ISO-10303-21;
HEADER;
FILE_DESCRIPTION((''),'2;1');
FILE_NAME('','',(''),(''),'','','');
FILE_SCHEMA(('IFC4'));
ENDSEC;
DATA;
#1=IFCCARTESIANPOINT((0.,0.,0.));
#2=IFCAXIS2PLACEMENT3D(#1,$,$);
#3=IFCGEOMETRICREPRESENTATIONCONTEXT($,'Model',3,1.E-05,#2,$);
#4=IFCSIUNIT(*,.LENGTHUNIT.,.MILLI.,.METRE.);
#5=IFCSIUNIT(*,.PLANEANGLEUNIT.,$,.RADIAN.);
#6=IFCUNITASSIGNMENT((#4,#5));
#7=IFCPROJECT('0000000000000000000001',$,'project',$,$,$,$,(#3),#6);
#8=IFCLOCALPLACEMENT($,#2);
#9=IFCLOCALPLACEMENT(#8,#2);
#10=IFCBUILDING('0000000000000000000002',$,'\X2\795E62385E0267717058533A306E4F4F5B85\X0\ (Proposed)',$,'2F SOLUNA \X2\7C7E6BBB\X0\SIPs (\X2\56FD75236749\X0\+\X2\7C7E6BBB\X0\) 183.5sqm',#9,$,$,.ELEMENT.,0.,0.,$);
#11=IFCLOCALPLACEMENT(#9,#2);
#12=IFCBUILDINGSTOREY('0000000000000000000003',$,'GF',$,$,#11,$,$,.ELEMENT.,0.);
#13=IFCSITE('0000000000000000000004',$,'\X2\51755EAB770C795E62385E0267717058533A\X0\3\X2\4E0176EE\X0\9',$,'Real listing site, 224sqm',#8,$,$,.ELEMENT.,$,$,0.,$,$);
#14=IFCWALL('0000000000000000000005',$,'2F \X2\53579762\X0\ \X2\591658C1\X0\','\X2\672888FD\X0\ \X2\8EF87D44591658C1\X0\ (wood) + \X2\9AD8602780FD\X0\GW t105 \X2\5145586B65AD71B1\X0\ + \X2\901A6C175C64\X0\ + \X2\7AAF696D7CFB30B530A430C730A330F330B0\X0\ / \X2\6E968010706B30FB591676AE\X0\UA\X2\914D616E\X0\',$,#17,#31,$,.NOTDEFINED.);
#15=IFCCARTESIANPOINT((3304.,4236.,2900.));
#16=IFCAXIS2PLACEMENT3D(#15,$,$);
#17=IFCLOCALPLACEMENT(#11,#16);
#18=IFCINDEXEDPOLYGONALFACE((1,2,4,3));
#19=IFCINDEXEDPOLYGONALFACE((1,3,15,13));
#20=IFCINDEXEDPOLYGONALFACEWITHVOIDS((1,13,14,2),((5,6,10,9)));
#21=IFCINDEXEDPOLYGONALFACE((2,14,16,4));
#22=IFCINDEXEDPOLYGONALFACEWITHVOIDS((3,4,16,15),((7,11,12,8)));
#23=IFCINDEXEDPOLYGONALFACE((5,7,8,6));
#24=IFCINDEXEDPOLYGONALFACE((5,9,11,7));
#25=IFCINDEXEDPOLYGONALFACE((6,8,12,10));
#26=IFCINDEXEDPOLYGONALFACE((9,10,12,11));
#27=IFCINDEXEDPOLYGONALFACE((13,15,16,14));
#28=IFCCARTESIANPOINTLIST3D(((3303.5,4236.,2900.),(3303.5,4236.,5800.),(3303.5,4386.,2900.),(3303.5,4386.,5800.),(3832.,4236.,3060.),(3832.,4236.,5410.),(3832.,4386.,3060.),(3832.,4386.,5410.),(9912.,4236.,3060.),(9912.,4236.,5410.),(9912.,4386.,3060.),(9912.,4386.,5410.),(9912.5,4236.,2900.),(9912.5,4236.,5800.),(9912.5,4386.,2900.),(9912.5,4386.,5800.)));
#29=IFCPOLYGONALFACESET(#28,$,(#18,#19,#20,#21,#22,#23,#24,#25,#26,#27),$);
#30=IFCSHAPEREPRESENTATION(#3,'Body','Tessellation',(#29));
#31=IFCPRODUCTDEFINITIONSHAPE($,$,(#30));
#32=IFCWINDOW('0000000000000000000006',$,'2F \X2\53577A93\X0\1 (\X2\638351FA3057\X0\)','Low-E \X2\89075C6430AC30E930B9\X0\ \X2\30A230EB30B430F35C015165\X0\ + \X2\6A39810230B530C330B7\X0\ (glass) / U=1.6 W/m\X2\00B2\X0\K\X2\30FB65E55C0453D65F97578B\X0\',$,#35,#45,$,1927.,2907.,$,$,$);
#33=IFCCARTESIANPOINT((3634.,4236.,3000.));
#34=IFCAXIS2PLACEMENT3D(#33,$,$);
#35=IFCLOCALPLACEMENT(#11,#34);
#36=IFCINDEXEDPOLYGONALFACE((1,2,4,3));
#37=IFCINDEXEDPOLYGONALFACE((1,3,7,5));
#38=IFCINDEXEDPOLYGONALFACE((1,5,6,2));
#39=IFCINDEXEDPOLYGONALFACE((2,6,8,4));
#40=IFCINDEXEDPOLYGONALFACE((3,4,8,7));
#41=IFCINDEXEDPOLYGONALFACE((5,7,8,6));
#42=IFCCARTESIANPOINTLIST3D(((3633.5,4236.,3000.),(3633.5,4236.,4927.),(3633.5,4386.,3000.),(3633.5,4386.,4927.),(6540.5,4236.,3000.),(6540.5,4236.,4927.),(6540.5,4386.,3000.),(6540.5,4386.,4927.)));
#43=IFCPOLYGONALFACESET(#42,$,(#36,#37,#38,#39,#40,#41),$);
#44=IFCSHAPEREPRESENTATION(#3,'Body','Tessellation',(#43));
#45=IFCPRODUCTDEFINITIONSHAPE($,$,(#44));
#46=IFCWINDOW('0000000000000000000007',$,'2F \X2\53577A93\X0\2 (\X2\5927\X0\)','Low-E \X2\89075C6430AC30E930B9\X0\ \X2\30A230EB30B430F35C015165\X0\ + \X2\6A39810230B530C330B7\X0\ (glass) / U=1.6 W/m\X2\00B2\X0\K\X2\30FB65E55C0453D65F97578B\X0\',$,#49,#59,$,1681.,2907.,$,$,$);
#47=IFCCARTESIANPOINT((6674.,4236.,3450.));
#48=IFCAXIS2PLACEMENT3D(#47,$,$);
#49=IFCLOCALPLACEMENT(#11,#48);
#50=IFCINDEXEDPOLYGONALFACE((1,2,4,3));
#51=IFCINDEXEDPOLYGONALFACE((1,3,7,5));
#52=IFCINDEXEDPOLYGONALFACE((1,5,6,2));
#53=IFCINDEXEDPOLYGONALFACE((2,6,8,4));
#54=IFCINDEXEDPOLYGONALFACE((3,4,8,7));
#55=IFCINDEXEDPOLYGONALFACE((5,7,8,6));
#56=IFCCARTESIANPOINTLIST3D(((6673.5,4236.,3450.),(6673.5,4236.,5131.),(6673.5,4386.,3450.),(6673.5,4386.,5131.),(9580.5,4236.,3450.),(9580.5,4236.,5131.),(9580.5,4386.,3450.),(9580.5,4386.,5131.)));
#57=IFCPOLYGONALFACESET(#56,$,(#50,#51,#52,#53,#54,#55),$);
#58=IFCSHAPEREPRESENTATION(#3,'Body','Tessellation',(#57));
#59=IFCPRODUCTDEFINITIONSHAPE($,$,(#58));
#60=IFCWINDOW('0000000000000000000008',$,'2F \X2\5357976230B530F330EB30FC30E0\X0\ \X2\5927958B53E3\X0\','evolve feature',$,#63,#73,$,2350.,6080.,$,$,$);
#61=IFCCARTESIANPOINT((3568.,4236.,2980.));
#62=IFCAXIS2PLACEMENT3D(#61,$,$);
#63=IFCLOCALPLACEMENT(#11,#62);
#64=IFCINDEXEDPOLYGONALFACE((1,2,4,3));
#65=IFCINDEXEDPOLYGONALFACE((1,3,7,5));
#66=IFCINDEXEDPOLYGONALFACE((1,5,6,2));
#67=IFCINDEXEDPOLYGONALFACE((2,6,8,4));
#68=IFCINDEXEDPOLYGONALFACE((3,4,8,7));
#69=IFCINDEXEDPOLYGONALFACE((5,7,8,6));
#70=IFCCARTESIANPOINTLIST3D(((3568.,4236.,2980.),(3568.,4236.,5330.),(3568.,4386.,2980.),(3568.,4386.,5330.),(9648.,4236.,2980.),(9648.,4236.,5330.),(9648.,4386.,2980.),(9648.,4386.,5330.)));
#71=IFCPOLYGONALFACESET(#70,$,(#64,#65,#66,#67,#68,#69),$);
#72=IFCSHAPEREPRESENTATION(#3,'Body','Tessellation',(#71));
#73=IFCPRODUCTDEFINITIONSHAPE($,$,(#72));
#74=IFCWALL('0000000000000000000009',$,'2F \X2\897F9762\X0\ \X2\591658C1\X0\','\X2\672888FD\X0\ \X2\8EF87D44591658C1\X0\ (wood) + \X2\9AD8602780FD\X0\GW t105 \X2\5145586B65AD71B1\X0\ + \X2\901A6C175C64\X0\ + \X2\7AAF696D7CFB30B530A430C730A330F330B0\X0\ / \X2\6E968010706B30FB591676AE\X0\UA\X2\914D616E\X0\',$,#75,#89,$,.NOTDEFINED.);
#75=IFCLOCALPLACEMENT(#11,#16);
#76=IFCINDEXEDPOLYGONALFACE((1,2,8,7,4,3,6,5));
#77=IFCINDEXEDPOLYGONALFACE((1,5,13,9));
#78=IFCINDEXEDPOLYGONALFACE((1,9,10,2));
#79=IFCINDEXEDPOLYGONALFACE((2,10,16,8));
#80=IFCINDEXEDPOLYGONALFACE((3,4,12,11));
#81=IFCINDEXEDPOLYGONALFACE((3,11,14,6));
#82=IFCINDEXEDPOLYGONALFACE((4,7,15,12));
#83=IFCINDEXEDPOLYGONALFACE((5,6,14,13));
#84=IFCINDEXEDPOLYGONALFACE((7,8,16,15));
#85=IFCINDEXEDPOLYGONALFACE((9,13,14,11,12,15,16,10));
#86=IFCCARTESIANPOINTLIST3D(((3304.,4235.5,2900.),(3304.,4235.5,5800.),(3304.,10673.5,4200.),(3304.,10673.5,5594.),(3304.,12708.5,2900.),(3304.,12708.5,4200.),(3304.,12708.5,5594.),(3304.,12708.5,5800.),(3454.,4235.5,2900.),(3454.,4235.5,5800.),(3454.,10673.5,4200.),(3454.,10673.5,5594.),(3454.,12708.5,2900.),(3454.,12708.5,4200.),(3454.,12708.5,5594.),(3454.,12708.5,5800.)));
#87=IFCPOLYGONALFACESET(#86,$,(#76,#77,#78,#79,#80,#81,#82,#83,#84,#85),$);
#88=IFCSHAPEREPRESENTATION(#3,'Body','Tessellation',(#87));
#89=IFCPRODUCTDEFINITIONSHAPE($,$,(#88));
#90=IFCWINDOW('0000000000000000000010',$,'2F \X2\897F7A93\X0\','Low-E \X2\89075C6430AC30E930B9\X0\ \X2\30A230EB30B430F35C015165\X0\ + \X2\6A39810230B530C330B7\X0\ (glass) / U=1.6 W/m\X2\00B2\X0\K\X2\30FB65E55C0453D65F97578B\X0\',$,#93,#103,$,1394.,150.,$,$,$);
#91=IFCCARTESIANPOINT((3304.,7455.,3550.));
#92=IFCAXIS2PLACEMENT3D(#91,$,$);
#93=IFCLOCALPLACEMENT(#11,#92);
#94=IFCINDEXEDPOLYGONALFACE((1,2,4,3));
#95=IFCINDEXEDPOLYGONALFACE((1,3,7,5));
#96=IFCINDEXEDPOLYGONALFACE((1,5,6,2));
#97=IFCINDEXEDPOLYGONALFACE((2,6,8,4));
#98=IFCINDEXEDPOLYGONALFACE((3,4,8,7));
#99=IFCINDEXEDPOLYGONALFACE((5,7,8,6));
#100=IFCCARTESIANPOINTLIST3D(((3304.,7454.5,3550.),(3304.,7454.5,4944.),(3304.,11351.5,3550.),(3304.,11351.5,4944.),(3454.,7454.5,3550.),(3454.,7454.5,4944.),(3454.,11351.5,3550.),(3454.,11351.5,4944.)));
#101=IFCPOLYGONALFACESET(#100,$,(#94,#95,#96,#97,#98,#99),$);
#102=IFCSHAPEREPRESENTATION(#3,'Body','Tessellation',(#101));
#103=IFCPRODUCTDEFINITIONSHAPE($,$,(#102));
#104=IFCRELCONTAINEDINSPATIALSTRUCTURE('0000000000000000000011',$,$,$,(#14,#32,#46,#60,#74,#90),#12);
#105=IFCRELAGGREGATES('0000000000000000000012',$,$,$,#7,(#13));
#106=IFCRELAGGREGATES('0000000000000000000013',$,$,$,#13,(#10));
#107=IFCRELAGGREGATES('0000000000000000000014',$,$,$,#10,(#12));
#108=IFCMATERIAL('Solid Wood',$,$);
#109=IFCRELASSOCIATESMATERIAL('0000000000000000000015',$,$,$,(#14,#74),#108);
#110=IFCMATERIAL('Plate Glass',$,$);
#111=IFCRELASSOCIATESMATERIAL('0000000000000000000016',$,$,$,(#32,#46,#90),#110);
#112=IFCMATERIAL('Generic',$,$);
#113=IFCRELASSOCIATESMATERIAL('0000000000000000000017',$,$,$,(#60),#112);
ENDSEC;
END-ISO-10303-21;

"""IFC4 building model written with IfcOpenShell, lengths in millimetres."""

from ifc_helpers import new_model, si_unit, frame, frame_2d, origin, place, context, project, spatial, rectangle, extrude, material, element, fill, save


model = new_model("IFC4")

# Units and contexts
model_context = context("Model", 3, precision=1e-05, world=origin())
ifc_project = project(units=[si_unit("LENGTHUNIT", "METRE", prefix="MILLI"), si_unit("PLANEANGLEUNIT", "RADIAN")], contexts=[model_context])

# Site, building, storey
site_placement = place(None, origin())
site = spatial("IfcSite", under=ifc_project, at=site_placement, Name="兵庫県神戸市東灘区3丁目9", ObjectType="Real listing site, 224sqm", CompositionType="ELEMENT", RefElevation=0.0)
building_placement = place(site_placement, origin())
building = spatial("IfcBuilding", under=site, at=building_placement, Name="神戸市東灘区の住宅 (Proposed)", ObjectType="2F SOLUNA 籾殻SIPs (国産杉+籾殻) 183.5sqm", CompositionType="ELEMENT", ElevationOfRefHeight=0.0, ElevationOfTerrain=0.0)
storey_placement = place(building_placement, origin())
storey = spatial("IfcBuildingStorey", under=building, at=storey_placement, Name="GF", CompositionType="ELEMENT", Elevation=0.0)

# Shared definitions
ifc_material_1 = material(Name="Solid Wood")
ifc_material_2 = material(Name="Generic")

# Shared definitions
ifc_material_3 = material(Name="Plate Glass")

# Wall, openings, windows
wall_1_placement = place(storey_placement, frame((3304.0, 4236.0, 2900.0)))
wall_1 = element("IfcWall", 1, at=wall_1_placement, inside=storey, material=ifc_material_1, Name="2F 南面 外壁", Description="木製 軸組外壁 (wood) + 高性能GW t105 充填断熱 + 通気層 + 窯業系サイディング / 準耐火・外皮UA配慮", PredefinedType="NOTDEFINED", context=model_context, shape_type="SweptSolid", body=[
    extrude(rectangle(XDim=6609.0, YDim=150.0, at=frame_2d((3304.0, 75.0))), frame((3304.0, 4236.0, 2900.0)), (0.0, 0.0, 1.0), 2900.0),
])
opening_1_placement = place(storey_placement, frame((3634.0, 4236.0, 3000.0)))
opening_1 = element("IfcOpeningElement", 2, at=opening_1_placement, cuts=wall_1, PredefinedType="NOTDEFINED", context=model_context, shape_type="SweptSolid", body=[
    extrude(rectangle(XDim=2907.0, YDim=150.0, at=frame_2d((1453.0, 75.0))), frame((3634.0, 4236.0, 3000.0)), (0.0, 0.0, 1.0), 1927.0),
])
opening_2_placement = place(storey_placement, frame((6674.0, 4236.0, 3450.0)))
opening_2 = element("IfcOpeningElement", 3, at=opening_2_placement, cuts=wall_1, PredefinedType="NOTDEFINED", context=model_context, shape_type="SweptSolid", body=[
    extrude(rectangle(XDim=2907.0, YDim=150.0, at=frame_2d((1453.0, 75.0))), frame((6674.0, 4236.0, 3450.0)), (0.0, 0.0, 1.0), 1681.0),
])
opening_3_placement = place(storey_placement, frame((3568.0, 4236.0, 2980.0)))
opening_3 = element("IfcOpeningElement", 4, at=opening_3_placement, cuts=wall_1, PredefinedType="NOTDEFINED", context=model_context, shape_type="SweptSolid", body=[
    extrude(rectangle(XDim=6080.0, YDim=150.0, at=frame_2d((3040.0, 75.0))), frame((3568.0, 4236.0, 2980.0)), (0.0, 0.0, 1.0), 2350.0),
])
window_1_placement = place(storey_placement, frame((3634.0, 4236.0, 3000.0)))
window_1 = element("IfcWindow", 5, at=window_1_placement, inside=storey, material=ifc_material_3, Name="2F 南窓1 (掃出し)", Description="Low-E 複層ガラス アルゴン封入 + 樹脂サッシ (glass) / U=1.6 W/m²K・日射取得型", OverallHeight=1927.0, OverallWidth=2907.0, context=model_context, shape_type="SweptSolid", body=[
    extrude(rectangle(XDim=2907.0, YDim=150.0, at=frame_2d((1453.0, 75.0))), frame((3634.0, 4236.0, 3000.0)), (0.0, 0.0, 1.0), 1927.0),
])
fill(opening_1, window_1)
window_2_placement = place(storey_placement, frame((6674.0, 4236.0, 3450.0)))
window_2 = element("IfcWindow", 6, at=window_2_placement, inside=storey, material=ifc_material_3, Name="2F 南窓2 (大)", Description="Low-E 複層ガラス アルゴン封入 + 樹脂サッシ (glass) / U=1.6 W/m²K・日射取得型", OverallHeight=1681.0, OverallWidth=2907.0, context=model_context, shape_type="SweptSolid", body=[
    extrude(rectangle(XDim=2907.0, YDim=150.0, at=frame_2d((1453.0, 75.0))), frame((6674.0, 4236.0, 3450.0)), (0.0, 0.0, 1.0), 1681.0),
])
fill(opening_2, window_2)
window_3_placement = place(storey_placement, frame((3568.0, 4236.0, 2980.0)))
window_3 = element("IfcWindow", 7, at=window_3_placement, inside=storey, material=ifc_material_2, Name="2F 南面サンルーム 大開口", Description="evolve feature", OverallHeight=2350.0, OverallWidth=6080.0, context=model_context, shape_type="SweptSolid", body=[
    extrude(rectangle(XDim=6080.0, YDim=150.0, at=frame_2d((3040.0, 75.0))), frame((3568.0, 4236.0, 2980.0)), (0.0, 0.0, 1.0), 2350.0),
])
fill(opening_3, window_3)

# Wall, opening, window
wall_2_placement = place(storey_placement, frame((3304.0, 4236.0, 2900.0)))
wall_2 = element("IfcWall", 8, at=wall_2_placement, inside=storey, material=ifc_material_1, Name="2F 西面 外壁", Description="木製 軸組外壁 (wood) + 高性能GW t105 充填断熱 + 通気層 + 窯業系サイディング / 準耐火・外皮UA配慮", PredefinedType="NOTDEFINED", context=model_context, shape_type="SweptSolid", body=[
    extrude(rectangle(XDim=150.0, YDim=8473.0, at=frame_2d((75.0, 4236.0))), frame((3304.0, 4236.0, 2900.0)), (0.0, 0.0, 1.0), 2900.0),
])
opening_4_placement = place(storey_placement, frame((3304.0, 7455.0, 3550.0)))
opening_4 = element("IfcOpeningElement", 9, at=opening_4_placement, cuts=wall_2, PredefinedType="NOTDEFINED", context=model_context, shape_type="SweptSolid", body=[
    extrude(rectangle(XDim=150.0, YDim=3897.0, at=frame_2d((75.0, 1948.0))), frame((3304.0, 7455.0, 3550.0)), (0.0, 0.0, 1.0), 1394.0),
])
window_4_placement = place(storey_placement, frame((3304.0, 7455.0, 3550.0)))
window_4 = element("IfcWindow", 10, at=window_4_placement, inside=storey, material=ifc_material_3, Name="2F 西窓", Description="Low-E 複層ガラス アルゴン封入 + 樹脂サッシ (glass) / U=1.6 W/m²K・日射取得型", OverallHeight=1394.0, OverallWidth=150.0, context=model_context, shape_type="SweptSolid", body=[
    extrude(rectangle(XDim=150.0, YDim=3897.0, at=frame_2d((75.0, 1948.0))), frame((3304.0, 7455.0, 3550.0)), (0.0, 0.0, 1.0), 1394.0),
])
fill(opening_4, window_4)

save(model, "model.ifc")
